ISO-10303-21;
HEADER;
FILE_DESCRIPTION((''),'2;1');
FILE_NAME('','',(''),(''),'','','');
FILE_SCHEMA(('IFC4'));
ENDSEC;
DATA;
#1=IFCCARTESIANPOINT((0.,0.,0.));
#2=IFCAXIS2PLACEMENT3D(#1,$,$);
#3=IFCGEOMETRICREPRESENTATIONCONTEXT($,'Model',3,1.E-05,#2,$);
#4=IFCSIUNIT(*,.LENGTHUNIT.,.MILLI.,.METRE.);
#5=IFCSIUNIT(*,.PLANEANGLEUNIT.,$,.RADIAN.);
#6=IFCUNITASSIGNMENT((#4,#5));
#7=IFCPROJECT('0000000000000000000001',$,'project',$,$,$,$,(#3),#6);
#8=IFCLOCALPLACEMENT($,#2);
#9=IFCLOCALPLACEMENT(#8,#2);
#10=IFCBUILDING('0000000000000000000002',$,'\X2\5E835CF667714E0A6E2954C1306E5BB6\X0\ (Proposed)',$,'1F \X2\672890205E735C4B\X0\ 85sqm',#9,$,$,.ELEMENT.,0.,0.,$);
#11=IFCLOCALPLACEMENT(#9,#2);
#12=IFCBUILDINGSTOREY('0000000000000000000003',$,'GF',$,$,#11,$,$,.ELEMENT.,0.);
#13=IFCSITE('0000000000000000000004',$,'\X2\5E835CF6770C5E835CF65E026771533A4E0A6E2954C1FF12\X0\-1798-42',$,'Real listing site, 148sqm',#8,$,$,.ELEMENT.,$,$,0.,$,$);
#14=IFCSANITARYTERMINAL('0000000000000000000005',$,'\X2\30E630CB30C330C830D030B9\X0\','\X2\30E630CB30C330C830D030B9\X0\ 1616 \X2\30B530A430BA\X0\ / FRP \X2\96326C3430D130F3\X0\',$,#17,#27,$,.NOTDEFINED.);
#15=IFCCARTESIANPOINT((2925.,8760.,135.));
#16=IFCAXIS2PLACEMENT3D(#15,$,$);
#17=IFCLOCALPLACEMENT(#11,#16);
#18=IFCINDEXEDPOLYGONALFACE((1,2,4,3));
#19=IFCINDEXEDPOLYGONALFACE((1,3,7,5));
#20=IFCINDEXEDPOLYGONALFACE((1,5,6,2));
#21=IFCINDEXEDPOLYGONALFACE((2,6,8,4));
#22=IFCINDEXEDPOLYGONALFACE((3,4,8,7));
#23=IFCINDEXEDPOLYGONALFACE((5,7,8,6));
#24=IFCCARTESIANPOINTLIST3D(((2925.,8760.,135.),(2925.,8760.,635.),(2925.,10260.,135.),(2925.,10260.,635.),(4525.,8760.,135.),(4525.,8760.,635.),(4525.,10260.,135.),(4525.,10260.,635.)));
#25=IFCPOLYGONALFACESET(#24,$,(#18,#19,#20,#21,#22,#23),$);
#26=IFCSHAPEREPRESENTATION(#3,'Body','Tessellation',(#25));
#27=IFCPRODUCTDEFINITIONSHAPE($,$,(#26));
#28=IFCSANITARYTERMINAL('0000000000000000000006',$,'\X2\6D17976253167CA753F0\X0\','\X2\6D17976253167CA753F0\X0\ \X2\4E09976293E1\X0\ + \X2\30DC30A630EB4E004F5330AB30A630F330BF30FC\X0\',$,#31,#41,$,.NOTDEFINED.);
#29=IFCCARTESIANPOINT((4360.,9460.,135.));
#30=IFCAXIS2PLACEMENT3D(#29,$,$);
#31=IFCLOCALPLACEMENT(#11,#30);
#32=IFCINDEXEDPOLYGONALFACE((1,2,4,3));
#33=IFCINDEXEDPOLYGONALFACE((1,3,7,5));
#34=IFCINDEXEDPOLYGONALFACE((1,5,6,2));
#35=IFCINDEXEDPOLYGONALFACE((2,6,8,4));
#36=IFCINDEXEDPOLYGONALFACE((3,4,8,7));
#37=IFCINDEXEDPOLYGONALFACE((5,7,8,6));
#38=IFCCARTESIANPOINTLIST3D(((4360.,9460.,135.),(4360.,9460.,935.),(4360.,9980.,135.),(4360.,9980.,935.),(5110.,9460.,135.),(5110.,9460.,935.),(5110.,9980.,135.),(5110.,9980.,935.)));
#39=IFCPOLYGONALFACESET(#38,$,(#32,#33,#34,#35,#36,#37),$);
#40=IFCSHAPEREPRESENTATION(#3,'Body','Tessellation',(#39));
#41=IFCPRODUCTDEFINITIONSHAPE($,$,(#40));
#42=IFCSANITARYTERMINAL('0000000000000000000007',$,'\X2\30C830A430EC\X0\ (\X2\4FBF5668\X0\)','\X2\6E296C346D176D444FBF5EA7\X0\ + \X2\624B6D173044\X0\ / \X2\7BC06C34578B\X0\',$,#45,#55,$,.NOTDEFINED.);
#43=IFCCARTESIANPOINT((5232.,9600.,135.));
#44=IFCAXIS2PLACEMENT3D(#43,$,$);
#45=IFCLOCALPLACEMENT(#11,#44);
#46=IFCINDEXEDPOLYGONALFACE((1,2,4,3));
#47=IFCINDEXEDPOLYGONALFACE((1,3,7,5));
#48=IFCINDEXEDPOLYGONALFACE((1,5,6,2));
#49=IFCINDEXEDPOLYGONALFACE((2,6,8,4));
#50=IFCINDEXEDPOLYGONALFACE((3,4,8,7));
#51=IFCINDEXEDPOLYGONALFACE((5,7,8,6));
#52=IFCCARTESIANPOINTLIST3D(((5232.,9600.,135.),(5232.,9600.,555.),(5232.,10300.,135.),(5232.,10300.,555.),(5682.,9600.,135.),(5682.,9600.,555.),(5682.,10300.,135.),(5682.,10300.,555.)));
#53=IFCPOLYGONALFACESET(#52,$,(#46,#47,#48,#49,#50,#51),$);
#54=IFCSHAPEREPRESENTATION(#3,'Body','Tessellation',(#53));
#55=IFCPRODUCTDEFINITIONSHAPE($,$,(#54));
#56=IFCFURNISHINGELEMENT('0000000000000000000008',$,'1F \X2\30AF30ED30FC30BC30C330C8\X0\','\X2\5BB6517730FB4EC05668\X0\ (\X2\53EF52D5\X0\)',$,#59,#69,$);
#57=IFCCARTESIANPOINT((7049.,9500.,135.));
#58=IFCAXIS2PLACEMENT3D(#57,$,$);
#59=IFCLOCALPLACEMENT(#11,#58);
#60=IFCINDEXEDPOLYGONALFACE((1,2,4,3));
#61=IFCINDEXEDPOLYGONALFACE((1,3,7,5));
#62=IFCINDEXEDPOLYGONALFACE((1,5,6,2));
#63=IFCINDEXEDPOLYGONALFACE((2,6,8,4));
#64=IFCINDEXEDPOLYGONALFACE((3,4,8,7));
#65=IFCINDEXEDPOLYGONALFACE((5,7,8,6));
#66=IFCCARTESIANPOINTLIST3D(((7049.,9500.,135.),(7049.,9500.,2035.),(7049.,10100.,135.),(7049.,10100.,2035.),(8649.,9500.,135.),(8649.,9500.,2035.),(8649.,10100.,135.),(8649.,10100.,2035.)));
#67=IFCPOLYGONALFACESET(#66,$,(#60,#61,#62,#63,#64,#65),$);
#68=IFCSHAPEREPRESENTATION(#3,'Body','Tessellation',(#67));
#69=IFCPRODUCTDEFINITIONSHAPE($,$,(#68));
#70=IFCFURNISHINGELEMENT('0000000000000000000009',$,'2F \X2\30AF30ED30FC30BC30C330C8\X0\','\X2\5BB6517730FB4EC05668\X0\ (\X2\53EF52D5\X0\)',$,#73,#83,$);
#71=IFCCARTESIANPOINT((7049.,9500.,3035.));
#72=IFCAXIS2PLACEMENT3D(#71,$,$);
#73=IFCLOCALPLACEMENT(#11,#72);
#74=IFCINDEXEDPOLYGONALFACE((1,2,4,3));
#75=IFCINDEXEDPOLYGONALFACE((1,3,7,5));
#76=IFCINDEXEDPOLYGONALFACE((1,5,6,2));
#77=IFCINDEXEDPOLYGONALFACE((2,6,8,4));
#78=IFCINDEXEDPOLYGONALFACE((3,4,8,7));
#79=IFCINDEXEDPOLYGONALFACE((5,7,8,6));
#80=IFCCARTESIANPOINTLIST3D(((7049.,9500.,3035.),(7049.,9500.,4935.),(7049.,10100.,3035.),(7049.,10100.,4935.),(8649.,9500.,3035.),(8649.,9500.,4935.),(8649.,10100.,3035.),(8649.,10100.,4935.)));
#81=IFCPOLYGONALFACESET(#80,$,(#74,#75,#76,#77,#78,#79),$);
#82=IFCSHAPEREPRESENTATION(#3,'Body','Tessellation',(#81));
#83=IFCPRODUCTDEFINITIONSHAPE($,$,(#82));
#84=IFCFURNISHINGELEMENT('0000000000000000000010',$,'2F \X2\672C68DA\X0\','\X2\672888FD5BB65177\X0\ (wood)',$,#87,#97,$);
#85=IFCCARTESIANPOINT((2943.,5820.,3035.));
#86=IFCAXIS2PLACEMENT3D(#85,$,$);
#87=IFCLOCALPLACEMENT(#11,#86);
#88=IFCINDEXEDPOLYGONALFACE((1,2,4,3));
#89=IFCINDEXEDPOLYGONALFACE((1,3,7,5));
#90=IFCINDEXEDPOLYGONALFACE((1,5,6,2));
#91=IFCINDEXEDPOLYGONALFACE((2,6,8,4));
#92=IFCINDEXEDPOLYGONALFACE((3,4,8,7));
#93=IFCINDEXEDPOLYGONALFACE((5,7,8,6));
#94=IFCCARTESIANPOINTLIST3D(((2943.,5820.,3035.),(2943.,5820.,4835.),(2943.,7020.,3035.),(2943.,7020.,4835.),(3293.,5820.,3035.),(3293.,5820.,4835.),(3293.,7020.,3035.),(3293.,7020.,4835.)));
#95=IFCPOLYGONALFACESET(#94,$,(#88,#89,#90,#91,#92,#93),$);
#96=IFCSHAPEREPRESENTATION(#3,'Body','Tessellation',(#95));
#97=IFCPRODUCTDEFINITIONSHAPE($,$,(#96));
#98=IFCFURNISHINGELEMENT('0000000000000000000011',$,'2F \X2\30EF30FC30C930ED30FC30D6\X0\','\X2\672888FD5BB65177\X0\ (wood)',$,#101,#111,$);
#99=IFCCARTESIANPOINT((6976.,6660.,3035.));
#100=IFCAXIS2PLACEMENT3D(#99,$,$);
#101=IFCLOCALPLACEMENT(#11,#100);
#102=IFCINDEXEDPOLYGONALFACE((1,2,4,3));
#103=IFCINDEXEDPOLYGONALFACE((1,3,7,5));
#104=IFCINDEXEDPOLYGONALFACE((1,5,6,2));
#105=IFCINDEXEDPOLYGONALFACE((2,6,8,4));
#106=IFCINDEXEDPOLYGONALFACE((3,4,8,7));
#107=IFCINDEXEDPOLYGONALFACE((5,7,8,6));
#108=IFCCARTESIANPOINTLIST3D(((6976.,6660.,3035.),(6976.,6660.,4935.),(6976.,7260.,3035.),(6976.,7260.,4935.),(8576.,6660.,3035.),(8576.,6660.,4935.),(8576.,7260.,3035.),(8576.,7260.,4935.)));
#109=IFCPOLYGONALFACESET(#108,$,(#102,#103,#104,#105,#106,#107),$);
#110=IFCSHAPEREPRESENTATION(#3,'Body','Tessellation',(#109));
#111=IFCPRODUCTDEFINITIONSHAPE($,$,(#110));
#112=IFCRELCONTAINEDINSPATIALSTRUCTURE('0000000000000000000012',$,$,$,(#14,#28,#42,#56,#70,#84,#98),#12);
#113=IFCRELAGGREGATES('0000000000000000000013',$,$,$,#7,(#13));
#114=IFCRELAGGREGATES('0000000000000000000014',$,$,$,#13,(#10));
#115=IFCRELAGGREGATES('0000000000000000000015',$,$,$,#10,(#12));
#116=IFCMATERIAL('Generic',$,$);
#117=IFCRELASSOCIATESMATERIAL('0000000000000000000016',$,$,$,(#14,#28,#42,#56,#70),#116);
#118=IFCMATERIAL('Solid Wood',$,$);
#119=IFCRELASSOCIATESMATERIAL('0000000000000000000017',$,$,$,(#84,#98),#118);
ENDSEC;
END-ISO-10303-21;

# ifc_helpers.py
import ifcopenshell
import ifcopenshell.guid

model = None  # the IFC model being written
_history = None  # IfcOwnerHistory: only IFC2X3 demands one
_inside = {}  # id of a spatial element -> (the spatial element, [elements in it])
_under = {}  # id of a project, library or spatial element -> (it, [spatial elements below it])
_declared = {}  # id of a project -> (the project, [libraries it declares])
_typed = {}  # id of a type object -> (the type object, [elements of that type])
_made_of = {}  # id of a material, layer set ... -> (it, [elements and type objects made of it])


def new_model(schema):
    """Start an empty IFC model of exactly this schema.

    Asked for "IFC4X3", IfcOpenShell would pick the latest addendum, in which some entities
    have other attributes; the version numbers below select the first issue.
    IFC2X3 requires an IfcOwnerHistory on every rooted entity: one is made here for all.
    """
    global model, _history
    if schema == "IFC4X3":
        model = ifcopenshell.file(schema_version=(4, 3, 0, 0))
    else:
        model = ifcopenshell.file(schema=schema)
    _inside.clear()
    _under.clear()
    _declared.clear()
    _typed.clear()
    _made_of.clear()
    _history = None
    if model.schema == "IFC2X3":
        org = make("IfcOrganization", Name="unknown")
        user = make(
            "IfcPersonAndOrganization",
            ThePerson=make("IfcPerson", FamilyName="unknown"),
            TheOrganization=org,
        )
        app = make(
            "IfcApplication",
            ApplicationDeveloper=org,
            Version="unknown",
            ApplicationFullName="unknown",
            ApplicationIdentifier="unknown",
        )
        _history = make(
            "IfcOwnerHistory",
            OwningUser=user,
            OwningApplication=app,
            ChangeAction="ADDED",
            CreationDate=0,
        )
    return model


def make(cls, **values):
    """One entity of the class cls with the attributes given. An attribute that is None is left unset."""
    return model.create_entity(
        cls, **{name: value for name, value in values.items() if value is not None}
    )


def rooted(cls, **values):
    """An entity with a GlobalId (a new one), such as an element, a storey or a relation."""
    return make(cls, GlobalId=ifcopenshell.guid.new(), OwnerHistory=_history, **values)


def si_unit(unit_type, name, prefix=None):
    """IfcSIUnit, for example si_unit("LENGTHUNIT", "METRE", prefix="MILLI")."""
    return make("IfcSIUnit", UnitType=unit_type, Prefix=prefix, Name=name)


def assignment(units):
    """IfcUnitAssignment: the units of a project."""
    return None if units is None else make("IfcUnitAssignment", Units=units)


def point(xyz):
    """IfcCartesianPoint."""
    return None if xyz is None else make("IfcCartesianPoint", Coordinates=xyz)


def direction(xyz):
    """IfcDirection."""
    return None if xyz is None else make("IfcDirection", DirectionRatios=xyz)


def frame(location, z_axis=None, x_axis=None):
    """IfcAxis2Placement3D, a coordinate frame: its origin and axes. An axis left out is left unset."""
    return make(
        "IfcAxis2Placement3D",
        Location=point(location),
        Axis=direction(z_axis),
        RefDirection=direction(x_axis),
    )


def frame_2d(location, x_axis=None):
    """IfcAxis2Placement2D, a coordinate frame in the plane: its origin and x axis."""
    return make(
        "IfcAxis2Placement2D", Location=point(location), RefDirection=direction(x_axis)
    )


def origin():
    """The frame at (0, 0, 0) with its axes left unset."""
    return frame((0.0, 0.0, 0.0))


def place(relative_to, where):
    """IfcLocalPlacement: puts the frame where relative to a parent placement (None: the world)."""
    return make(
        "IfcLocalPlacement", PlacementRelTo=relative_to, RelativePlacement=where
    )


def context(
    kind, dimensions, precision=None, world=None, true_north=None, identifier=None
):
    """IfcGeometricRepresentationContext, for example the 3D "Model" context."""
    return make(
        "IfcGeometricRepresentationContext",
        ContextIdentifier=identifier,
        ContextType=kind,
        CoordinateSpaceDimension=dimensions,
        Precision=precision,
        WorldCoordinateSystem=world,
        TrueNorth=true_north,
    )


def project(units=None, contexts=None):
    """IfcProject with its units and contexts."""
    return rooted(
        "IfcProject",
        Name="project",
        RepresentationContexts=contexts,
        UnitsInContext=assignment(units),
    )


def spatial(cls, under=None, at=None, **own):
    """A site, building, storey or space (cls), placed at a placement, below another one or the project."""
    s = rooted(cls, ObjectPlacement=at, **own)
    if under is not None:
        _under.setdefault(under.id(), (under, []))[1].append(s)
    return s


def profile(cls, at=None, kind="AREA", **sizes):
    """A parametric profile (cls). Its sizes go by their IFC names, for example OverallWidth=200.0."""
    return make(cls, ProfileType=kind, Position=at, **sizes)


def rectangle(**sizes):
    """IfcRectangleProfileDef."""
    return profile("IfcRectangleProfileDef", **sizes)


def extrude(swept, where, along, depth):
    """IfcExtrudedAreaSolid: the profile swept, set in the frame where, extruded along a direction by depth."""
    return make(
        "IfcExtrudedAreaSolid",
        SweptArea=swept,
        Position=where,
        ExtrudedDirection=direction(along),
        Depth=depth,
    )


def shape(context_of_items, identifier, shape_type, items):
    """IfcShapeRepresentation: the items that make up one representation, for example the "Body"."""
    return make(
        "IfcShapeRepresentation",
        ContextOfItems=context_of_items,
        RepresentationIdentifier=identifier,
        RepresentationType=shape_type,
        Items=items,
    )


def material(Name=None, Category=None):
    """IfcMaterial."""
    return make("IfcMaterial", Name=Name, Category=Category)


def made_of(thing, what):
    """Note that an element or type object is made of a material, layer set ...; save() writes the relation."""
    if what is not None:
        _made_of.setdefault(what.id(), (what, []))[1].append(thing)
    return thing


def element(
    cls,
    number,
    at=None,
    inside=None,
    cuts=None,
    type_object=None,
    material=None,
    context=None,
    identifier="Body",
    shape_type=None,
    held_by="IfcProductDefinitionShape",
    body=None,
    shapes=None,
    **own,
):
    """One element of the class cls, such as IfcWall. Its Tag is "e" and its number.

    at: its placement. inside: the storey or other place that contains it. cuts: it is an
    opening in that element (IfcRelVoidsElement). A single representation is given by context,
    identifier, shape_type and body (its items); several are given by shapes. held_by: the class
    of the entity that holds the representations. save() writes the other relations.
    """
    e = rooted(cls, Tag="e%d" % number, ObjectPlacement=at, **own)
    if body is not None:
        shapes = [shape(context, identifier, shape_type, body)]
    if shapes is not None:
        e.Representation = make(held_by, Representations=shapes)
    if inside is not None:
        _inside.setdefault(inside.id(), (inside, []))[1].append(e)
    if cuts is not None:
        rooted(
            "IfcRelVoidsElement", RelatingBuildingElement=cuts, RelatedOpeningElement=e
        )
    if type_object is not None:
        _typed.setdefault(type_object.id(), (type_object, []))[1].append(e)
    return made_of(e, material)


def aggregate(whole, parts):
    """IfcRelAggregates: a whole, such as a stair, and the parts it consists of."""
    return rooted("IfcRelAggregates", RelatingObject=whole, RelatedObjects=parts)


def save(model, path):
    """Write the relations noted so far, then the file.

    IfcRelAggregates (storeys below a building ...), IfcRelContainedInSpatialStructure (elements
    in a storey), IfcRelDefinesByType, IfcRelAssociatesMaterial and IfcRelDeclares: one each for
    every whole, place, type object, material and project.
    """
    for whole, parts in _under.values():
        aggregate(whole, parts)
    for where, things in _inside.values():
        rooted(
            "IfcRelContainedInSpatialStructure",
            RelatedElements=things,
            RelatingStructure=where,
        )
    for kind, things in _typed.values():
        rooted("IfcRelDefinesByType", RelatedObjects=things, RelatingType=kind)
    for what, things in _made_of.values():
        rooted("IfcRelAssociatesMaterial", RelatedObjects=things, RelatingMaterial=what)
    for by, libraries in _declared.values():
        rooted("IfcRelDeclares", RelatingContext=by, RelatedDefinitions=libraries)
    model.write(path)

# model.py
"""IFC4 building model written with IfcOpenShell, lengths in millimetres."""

from ifc_helpers import new_model, si_unit, frame, frame_2d, origin, place, context, project, spatial, rectangle, extrude, material, element, save


model = new_model("IFC4")

# Units and contexts
model_context = context("Model", 3, precision=1e-05, world=origin())
ifc_project = project(units=[si_unit("LENGTHUNIT", "METRE", prefix="MILLI"), si_unit("PLANEANGLEUNIT", "RADIAN")], contexts=[model_context])

# Site, building, storey
site_placement = place(None, origin())
site = spatial("IfcSite", under=ifc_project, at=site_placement, Name="広島県広島市東区上温品２-1798-42", ObjectType="Real listing site, 148sqm", CompositionType="ELEMENT", RefElevation=0.0)
building_placement = place(site_placement, origin())
building = spatial("IfcBuilding", under=site, at=building_placement, Name="広島東上温品の家 (Proposed)", ObjectType="1F 木造平屋 85sqm", CompositionType="ELEMENT", ElevationOfRefHeight=0.0, ElevationOfTerrain=0.0)
storey_placement = place(building_placement, origin())
storey = spatial("IfcBuildingStorey", under=building, at=storey_placement, Name="GF", CompositionType="ELEMENT", Elevation=0.0)

# Shared definitions
ifc_material_1 = material(Name="Solid Wood")

# Shared definitions
ifc_material_2 = material(Name="Generic")

# Sanitary terminals
sanitary_terminal_1_placement = place(storey_placement, frame((2925.0, 8760.0, 135.0)))
element("IfcSanitaryTerminal", 1, at=sanitary_terminal_1_placement, inside=storey, material=ifc_material_2, Name="ユニットバス", Description="ユニットバス 1616 サイズ / FRP 防水パン", PredefinedType="NOTDEFINED", context=model_context, shape_type="SweptSolid", body=[
    extrude(rectangle(XDim=1600.0, YDim=1500.0, at=frame_2d((800.0, 750.0))), frame((2925.0, 8760.0, 135.0)), (0.0, 0.0, 1.0), 500.0),
])
sanitary_terminal_2_placement = place(storey_placement, frame((4360.0, 9460.0, 135.0)))
element("IfcSanitaryTerminal", 2, at=sanitary_terminal_2_placement, inside=storey, material=ifc_material_2, Name="洗面化粧台", Description="洗面化粧台 三面鏡 + ボウル一体カウンター", PredefinedType="NOTDEFINED", context=model_context, shape_type="SweptSolid", body=[
    extrude(rectangle(XDim=750.0, YDim=520.0, at=frame_2d((375.0, 260.0))), frame((4360.0, 9460.0, 135.0)), (0.0, 0.0, 1.0), 800.0),
])
sanitary_terminal_3_placement = place(storey_placement, frame((5232.0, 9600.0, 135.0)))
element("IfcSanitaryTerminal", 3, at=sanitary_terminal_3_placement, inside=storey, material=ifc_material_2, Name="トイレ (便器)", Description="温水洗浄便座 + 手洗い / 節水型", PredefinedType="NOTDEFINED", context=model_context, shape_type="SweptSolid", body=[
    extrude(rectangle(XDim=450.0, YDim=700.0, at=frame_2d((225.0, 350.0))), frame((5232.0, 9600.0, 135.0)), (0.0, 0.0, 1.0), 420.0),
])

# Furnishing elements
furnishing_1_placement = place(storey_placement, frame((7049.0, 9500.0, 135.0)))
element("IfcFurnishingElement", 4, at=furnishing_1_placement, inside=storey, material=ifc_material_2, Name="1F クローゼット", Description="家具・什器 (可動)", context=model_context, shape_type="SweptSolid", body=[
    extrude(rectangle(XDim=1600.0, YDim=600.0, at=frame_2d((800.0, 300.0))), frame((7049.0, 9500.0, 135.0)), (0.0, 0.0, 1.0), 1900.0),
])
furnishing_2_placement = place(storey_placement, frame((7049.0, 9500.0, 3035.0)))
element("IfcFurnishingElement", 5, at=furnishing_2_placement, inside=storey, material=ifc_material_2, Name="2F クローゼット", Description="家具・什器 (可動)", context=model_context, shape_type="SweptSolid", body=[
    extrude(rectangle(XDim=1600.0, YDim=600.0, at=frame_2d((800.0, 300.0))), frame((7049.0, 9500.0, 3035.0)), (0.0, 0.0, 1.0), 1900.0),
])
furnishing_3_placement = place(storey_placement, frame((2943.0, 5820.0, 3035.0)))
element("IfcFurnishingElement", 6, at=furnishing_3_placement, inside=storey, material=ifc_material_1, Name="2F 本棚", Description="木製家具 (wood)", context=model_context, shape_type="SweptSolid", body=[
    extrude(rectangle(XDim=350.0, YDim=1200.0, at=frame_2d((175.0, 600.0))), frame((2943.0, 5820.0, 3035.0)), (0.0, 0.0, 1.0), 1800.0),
])
furnishing_4_placement = place(storey_placement, frame((6976.0, 6660.0, 3035.0)))
element("IfcFurnishingElement", 7, at=furnishing_4_placement, inside=storey, material=ifc_material_1, Name="2F ワードローブ", Description="木製家具 (wood)", context=model_context, shape_type="SweptSolid", body=[
    extrude(rectangle(XDim=1600.0, YDim=600.0, at=frame_2d((800.0, 300.0))), frame((6976.0, 6660.0, 3035.0)), (0.0, 0.0, 1.0), 1900.0),
])

save(model, "model.ifc")
